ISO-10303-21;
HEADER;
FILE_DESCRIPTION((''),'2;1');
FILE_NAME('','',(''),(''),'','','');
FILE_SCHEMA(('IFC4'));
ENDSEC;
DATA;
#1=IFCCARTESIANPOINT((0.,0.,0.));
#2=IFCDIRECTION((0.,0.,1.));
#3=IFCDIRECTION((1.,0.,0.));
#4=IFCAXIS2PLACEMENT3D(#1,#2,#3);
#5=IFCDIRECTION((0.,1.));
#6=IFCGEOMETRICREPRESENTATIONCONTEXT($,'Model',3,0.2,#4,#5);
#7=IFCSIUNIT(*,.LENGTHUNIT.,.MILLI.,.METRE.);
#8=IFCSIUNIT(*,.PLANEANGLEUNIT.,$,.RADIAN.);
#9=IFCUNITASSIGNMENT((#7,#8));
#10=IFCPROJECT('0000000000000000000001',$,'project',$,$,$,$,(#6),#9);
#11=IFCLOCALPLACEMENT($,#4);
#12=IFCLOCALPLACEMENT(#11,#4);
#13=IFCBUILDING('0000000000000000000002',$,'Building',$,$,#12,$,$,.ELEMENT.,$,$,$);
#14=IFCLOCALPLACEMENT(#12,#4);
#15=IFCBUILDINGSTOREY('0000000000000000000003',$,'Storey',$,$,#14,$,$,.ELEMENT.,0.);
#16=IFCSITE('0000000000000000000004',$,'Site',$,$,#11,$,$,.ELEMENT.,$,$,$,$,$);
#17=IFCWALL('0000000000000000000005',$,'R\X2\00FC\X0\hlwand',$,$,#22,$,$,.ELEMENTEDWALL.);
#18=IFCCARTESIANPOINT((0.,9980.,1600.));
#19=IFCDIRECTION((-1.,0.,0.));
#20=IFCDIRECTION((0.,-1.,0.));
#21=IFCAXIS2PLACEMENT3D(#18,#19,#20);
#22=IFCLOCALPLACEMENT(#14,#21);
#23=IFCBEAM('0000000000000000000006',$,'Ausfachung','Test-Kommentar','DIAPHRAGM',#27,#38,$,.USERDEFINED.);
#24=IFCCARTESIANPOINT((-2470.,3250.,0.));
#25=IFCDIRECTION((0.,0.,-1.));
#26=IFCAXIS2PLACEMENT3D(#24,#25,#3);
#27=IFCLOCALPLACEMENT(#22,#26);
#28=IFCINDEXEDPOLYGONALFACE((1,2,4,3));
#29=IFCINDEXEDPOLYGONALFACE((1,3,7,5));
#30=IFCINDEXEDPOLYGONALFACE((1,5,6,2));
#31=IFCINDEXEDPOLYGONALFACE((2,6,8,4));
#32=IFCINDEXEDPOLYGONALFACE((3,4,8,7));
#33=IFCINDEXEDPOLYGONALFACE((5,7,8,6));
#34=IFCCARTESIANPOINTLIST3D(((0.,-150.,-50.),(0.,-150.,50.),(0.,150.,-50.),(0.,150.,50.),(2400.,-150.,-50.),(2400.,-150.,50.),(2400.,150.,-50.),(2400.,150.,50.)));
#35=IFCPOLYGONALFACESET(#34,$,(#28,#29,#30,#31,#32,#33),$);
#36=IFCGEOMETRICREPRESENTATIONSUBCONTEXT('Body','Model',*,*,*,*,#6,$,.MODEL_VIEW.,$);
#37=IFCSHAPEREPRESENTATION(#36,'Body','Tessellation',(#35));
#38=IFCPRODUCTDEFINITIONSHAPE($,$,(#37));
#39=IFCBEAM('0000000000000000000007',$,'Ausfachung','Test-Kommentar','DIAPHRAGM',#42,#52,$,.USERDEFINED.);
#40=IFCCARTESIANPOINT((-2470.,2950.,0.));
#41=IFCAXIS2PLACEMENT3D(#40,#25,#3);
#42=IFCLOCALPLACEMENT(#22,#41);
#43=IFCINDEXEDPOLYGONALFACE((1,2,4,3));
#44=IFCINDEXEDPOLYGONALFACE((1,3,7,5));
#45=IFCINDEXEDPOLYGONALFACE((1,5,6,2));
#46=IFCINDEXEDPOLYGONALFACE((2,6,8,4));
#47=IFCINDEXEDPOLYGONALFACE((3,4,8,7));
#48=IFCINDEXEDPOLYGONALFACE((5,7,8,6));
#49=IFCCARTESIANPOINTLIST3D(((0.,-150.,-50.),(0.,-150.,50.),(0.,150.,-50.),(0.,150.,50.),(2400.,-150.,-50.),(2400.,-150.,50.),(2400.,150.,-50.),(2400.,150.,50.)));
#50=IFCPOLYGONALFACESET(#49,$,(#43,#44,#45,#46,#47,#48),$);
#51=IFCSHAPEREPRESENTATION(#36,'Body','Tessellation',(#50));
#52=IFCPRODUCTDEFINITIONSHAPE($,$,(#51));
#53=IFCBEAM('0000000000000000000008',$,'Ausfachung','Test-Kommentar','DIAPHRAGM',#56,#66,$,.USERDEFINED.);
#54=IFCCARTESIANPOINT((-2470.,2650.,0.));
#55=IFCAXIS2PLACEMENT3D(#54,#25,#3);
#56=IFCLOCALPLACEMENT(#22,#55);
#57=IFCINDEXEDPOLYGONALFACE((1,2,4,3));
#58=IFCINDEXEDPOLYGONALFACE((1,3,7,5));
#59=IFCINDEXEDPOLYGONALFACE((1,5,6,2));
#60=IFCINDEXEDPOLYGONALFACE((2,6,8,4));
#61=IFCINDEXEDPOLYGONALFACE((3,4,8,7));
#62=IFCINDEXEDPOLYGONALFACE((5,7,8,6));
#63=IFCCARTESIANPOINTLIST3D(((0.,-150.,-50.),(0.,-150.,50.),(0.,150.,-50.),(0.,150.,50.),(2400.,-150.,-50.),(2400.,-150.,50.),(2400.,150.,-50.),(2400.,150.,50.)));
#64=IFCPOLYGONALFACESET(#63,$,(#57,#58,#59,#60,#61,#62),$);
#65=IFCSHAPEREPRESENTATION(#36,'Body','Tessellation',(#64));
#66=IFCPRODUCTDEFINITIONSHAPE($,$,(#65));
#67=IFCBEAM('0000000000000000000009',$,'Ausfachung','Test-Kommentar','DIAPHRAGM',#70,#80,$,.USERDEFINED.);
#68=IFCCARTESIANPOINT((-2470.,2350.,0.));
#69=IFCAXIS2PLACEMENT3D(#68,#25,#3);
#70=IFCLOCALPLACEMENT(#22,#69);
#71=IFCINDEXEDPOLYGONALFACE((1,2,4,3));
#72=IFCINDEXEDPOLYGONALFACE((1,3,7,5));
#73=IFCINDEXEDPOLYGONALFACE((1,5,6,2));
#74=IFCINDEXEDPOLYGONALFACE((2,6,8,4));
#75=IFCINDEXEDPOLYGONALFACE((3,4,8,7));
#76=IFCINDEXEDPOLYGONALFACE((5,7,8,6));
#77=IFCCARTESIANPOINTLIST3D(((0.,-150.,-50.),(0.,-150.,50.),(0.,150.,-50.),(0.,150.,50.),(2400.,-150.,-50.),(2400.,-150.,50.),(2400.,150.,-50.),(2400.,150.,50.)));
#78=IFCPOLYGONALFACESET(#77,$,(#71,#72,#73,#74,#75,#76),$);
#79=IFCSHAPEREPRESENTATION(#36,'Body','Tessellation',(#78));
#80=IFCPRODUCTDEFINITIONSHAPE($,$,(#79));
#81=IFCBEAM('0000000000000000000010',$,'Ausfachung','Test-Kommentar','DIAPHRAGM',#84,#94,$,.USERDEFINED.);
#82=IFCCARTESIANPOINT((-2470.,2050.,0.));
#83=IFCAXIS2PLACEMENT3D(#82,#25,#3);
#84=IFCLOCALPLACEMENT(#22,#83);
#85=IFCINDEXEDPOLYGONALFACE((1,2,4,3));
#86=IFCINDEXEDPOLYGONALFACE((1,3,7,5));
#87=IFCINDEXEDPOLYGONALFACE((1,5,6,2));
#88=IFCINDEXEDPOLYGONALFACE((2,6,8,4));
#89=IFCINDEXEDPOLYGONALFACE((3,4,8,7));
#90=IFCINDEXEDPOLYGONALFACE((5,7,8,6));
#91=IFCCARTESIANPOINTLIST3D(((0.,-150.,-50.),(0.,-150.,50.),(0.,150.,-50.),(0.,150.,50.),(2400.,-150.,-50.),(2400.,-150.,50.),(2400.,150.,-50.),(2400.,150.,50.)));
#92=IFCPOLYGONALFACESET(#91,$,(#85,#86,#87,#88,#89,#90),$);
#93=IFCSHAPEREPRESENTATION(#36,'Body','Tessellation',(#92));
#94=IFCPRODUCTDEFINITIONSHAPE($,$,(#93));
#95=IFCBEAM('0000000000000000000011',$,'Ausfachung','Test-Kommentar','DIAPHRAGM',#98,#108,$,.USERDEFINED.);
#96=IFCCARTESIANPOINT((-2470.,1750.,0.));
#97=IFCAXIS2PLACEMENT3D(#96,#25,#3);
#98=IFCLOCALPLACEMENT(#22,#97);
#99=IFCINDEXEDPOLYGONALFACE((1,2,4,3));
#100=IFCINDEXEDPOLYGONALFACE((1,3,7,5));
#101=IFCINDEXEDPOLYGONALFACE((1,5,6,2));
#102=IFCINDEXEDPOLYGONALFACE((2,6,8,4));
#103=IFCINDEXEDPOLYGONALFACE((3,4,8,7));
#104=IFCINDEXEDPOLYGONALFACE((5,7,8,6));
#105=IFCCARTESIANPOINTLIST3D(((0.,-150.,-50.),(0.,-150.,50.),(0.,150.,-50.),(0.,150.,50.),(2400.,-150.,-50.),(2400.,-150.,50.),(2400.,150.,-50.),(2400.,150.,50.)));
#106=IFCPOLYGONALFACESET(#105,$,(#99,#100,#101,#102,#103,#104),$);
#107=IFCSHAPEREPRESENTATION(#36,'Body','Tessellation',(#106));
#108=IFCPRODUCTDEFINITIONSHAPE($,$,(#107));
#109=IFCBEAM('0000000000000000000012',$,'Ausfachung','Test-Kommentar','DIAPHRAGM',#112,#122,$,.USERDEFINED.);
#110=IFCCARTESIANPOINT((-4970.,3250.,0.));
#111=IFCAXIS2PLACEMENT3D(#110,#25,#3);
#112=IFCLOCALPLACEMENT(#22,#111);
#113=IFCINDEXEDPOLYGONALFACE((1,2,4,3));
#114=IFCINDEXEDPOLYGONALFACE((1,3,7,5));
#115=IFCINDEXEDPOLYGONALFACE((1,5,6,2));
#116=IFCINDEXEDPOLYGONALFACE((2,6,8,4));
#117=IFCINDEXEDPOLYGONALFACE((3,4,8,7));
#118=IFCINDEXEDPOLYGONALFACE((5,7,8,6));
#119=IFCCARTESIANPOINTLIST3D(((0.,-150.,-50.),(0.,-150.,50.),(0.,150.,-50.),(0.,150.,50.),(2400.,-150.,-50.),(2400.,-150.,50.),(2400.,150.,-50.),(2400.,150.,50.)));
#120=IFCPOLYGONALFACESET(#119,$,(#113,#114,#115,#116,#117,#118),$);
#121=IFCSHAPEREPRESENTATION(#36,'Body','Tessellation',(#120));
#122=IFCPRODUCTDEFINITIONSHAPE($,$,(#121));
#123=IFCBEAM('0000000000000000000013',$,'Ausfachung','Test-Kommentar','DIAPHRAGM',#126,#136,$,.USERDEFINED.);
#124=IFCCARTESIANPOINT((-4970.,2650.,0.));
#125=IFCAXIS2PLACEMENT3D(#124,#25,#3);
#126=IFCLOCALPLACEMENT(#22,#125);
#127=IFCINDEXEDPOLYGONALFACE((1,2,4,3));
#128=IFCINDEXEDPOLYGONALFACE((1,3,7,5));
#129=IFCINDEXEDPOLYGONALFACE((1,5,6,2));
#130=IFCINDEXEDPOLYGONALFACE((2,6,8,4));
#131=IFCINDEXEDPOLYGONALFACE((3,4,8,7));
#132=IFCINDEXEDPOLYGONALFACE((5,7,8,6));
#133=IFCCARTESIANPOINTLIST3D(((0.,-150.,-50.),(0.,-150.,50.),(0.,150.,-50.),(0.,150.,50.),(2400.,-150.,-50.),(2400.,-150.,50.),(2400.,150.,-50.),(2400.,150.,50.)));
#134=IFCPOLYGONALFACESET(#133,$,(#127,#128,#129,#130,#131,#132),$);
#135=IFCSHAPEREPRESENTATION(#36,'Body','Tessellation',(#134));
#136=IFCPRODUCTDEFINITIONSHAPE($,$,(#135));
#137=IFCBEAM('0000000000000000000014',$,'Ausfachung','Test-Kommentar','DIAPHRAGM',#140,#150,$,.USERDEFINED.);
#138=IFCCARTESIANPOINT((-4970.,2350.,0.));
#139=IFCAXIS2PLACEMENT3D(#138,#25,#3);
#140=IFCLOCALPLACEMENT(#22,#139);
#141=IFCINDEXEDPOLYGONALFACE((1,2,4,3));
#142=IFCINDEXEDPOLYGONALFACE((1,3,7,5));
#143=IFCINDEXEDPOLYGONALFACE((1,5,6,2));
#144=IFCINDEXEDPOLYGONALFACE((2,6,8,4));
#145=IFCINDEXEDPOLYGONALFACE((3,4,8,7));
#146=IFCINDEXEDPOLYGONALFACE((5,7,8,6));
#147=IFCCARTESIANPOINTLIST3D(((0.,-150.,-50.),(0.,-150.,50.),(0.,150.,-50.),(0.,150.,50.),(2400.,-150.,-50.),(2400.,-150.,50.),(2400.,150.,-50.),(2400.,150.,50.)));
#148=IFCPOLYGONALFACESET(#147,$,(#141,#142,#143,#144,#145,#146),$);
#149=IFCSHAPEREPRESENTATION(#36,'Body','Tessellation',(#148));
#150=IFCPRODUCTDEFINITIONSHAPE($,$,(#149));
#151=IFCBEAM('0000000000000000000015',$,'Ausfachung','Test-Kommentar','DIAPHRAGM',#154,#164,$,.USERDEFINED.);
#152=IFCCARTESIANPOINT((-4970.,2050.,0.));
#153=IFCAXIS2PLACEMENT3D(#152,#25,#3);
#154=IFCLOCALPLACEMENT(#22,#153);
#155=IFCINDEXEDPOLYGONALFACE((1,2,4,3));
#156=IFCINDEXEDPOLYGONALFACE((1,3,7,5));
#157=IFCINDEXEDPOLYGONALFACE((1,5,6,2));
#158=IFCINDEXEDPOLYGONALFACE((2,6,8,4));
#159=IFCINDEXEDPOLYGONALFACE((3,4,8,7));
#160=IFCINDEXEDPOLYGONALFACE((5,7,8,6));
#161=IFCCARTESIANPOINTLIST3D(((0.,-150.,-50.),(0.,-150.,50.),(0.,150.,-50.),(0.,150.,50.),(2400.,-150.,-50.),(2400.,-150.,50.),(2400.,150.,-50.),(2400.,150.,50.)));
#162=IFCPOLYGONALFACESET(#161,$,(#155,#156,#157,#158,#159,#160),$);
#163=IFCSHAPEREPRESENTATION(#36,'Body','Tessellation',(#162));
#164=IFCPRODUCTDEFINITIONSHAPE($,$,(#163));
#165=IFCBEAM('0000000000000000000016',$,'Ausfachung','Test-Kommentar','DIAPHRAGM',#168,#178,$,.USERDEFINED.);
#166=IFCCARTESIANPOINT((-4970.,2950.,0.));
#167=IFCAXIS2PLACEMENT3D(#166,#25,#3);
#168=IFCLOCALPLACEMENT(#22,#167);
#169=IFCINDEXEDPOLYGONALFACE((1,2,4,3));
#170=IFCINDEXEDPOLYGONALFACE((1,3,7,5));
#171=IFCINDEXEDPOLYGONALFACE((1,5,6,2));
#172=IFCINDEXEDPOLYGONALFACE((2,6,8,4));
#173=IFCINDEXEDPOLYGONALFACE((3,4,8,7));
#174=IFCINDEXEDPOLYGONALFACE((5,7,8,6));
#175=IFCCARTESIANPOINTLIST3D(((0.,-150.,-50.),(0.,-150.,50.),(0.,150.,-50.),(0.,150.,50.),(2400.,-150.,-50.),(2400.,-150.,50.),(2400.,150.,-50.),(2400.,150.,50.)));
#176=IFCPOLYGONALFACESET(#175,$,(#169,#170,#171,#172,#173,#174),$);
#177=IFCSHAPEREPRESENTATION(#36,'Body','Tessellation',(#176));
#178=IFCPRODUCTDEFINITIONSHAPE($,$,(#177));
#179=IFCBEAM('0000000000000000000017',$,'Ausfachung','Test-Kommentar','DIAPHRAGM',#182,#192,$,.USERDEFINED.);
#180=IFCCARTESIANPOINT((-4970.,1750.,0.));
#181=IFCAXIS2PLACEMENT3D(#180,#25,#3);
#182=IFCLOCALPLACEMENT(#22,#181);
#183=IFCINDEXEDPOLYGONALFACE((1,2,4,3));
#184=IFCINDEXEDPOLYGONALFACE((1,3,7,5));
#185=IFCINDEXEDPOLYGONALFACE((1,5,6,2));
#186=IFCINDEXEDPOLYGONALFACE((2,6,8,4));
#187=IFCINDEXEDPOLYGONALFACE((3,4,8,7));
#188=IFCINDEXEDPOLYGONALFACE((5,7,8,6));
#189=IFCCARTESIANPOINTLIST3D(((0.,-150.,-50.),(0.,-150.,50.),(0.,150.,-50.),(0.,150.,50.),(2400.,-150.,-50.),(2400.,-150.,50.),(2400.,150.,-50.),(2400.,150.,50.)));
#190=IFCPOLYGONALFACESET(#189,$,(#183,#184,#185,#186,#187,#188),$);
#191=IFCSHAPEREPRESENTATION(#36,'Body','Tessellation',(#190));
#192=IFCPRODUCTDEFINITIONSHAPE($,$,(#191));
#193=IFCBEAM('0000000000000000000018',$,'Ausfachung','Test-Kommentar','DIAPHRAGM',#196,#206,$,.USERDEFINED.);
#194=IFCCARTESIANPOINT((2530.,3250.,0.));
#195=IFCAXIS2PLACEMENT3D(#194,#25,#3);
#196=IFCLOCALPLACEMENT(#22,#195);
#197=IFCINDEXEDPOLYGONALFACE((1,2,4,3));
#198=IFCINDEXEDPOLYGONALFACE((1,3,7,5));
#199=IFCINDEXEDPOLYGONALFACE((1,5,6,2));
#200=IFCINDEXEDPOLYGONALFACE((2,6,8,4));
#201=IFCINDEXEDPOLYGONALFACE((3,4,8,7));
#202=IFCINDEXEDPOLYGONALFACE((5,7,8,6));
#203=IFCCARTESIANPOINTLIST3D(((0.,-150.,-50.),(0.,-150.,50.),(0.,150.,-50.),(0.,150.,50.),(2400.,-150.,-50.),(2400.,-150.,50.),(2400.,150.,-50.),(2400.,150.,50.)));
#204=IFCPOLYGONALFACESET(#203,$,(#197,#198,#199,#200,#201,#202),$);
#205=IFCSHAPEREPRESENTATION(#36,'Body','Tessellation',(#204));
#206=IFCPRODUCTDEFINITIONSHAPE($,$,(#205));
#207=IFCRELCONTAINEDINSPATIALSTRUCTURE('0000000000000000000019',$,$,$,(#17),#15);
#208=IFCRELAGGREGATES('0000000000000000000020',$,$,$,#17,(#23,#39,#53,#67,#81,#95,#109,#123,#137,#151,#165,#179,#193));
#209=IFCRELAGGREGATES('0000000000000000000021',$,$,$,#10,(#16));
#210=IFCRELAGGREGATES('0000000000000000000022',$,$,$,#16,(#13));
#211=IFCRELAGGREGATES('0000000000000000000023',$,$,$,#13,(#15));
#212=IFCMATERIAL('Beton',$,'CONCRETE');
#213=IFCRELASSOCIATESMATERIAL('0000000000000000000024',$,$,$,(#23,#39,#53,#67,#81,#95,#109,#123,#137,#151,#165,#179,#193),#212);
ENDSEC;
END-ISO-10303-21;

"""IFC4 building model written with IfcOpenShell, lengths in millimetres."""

from ifc_helpers import new_model, si_unit, direction, frame, origin_with_axes, place, context, subcontext, project, spatial, line, indexed_curve, outline, extrude, material, element, aggregate, save


model = new_model("IFC4")

# Units and contexts
model_context = context("Model", 3, precision=0.2, world=origin_with_axes(), true_north=direction((0.0, 1.0)))
body_context = subcontext(model_context, "Body", "Model", "MODEL_VIEW")
ifc_project = project(units=[si_unit("LENGTHUNIT", "METRE", prefix="MILLI"), si_unit("PLANEANGLEUNIT", "RADIAN")], contexts=[model_context])

# Site, building, storey
site_placement = place(None, origin_with_axes())
site = spatial("IfcSite", under=ifc_project, at=site_placement, Name="Site", CompositionType="ELEMENT")
building_placement = place(site_placement, origin_with_axes())
building = spatial("IfcBuilding", under=site, at=building_placement, Name="Building", CompositionType="ELEMENT")
storey_placement = place(building_placement, origin_with_axes())
storey = spatial("IfcBuildingStorey", under=building, at=storey_placement, Name="Storey", CompositionType="ELEMENT", Elevation=0.0)

# Wall, beams
wall_placement = place(storey_placement, frame((0.0, 9980.0, 1600.0), z_axis=(-1.0, 0.0, 0.0), x_axis=(0.0, -1.0, 0.0)))
wall = element("IfcWall", 1, at=wall_placement, inside=storey, Name="Rühlwand", PredefinedType="ELEMENTEDWALL")
ifc_material_1 = material(Name="Beton", Category="CONCRETE")
beam_1_placement = place(wall_placement, frame((-2470.0, 3250.0, 0.0), z_axis=(0.0, 0.0, -1.0), x_axis=(1.0, 0.0, 0.0)))
beam_1 = element("IfcBeam", 2, at=beam_1_placement, material=ifc_material_1, Name="Ausfachung", Description="Test-Kommentar", ObjectType="DIAPHRAGM", PredefinedType="USERDEFINED", context=body_context, shape_type="SolidModel", body=[
    extrude(outline(indexed_curve([(-50.0, -150.0), (50.0, -150.0), (50.0, 150.0), (-50.0, 150.0)], segments=[line(1, 2, 3, 4, 1)])), frame((0.0, 0.0, 0.0), z_axis=(-1.0, 0.0, 0.0), x_axis=(0.0, 0.0, 1.0)), (0.0, 0.0, -1.0), 2400.0),
])
beam_2_placement = place(wall_placement, frame((-2470.0, 2950.0, 0.0), z_axis=(0.0, 0.0, -1.0), x_axis=(1.0, 0.0, 0.0)))
beam_2 = element("IfcBeam", 3, at=beam_2_placement, material=ifc_material_1, Name="Ausfachung", Description="Test-Kommentar", ObjectType="DIAPHRAGM", PredefinedType="USERDEFINED", context=body_context, shape_type="SolidModel", body=[
    extrude(outline(indexed_curve([(-50.0, -150.0), (50.0, -150.0), (50.0, 150.0), (-50.0, 150.0)], segments=[line(1, 2, 3, 4, 1)])), frame((0.0, 0.0, 0.0), z_axis=(-1.0, 0.0, 0.0), x_axis=(0.0, 0.0, 1.0)), (0.0, 0.0, -1.0), 2400.0),
])
beam_3_placement = place(wall_placement, frame((-2470.0, 2650.0, 0.0), z_axis=(0.0, 0.0, -1.0), x_axis=(1.0, 0.0, 0.0)))
beam_3 = element("IfcBeam", 4, at=beam_3_placement, material=ifc_material_1, Name="Ausfachung", Description="Test-Kommentar", ObjectType="DIAPHRAGM", PredefinedType="USERDEFINED", context=body_context, shape_type="SolidModel", body=[
    extrude(outline(indexed_curve([(-50.0, -150.0), (50.0, -150.0), (50.0, 150.0), (-50.0, 150.0)], segments=[line(1, 2, 3, 4, 1)])), frame((0.0, 0.0, 0.0), z_axis=(-1.0, 0.0, 0.0), x_axis=(0.0, 0.0, 1.0)), (0.0, 0.0, -1.0), 2400.0),
])
beam_4_placement = place(wall_placement, frame((-2470.0, 2350.0, 0.0), z_axis=(0.0, 0.0, -1.0), x_axis=(1.0, 0.0, 0.0)))
beam_4 = element("IfcBeam", 5, at=beam_4_placement, material=ifc_material_1, Name="Ausfachung", Description="Test-Kommentar", ObjectType="DIAPHRAGM", PredefinedType="USERDEFINED", context=body_context, shape_type="SolidModel", body=[
    extrude(outline(indexed_curve([(-50.0, -150.0), (50.0, -150.0), (50.0, 150.0), (-50.0, 150.0)], segments=[line(1, 2, 3, 4, 1)])), frame((0.0, 0.0, 0.0), z_axis=(-1.0, 0.0, 0.0), x_axis=(0.0, 0.0, 1.0)), (0.0, 0.0, -1.0), 2400.0),
])
beam_5_placement = place(wall_placement, frame((-2470.0, 2050.0, 0.0), z_axis=(0.0, 0.0, -1.0), x_axis=(1.0, 0.0, 0.0)))
beam_5 = element("IfcBeam", 6, at=beam_5_placement, material=ifc_material_1, Name="Ausfachung", Description="Test-Kommentar", ObjectType="DIAPHRAGM", PredefinedType="USERDEFINED", context=body_context, shape_type="SolidModel", body=[
    extrude(outline(indexed_curve([(-50.0, -150.0), (50.0, -150.0), (50.0, 150.0), (-50.0, 150.0)], segments=[line(1, 2, 3, 4, 1)])), frame((0.0, 0.0, 0.0), z_axis=(-1.0, 0.0, 0.0), x_axis=(0.0, 0.0, 1.0)), (0.0, 0.0, -1.0), 2400.0),
])
beam_6_placement = place(wall_placement, frame((-2470.0, 1750.0, 0.0), z_axis=(0.0, 0.0, -1.0), x_axis=(1.0, 0.0, 0.0)))
beam_6 = element("IfcBeam", 7, at=beam_6_placement, material=ifc_material_1, Name="Ausfachung", Description="Test-Kommentar", ObjectType="DIAPHRAGM", PredefinedType="USERDEFINED", context=body_context, shape_type="SolidModel", body=[
    extrude(outline(indexed_curve([(-50.0, -150.0), (50.0, -150.0), (50.0, 150.0), (-50.0, 150.0)], segments=[line(1, 2, 3, 4, 1)])), frame((0.0, 0.0, 0.0), z_axis=(-1.0, 0.0, 0.0), x_axis=(0.0, 0.0, 1.0)), (0.0, 0.0, -1.0), 2400.0),
])
beam_7_placement = place(wall_placement, frame((-4970.0, 3250.0, 0.0), z_axis=(0.0, 0.0, -1.0), x_axis=(1.0, 0.0, 0.0)))
beam_7 = element("IfcBeam", 8, at=beam_7_placement, material=ifc_material_1, Name="Ausfachung", Description="Test-Kommentar", ObjectType="DIAPHRAGM", PredefinedType="USERDEFINED", context=body_context, shape_type="SolidModel", body=[
    extrude(outline(indexed_curve([(-50.0, -150.0), (50.0, -150.0), (50.0, 150.0), (-50.0, 150.0)], segments=[line(1, 2, 3, 4, 1)])), frame((0.0, 0.0, 0.0), z_axis=(-1.0, 0.0, 0.0), x_axis=(0.0, 0.0, 1.0)), (0.0, 0.0, -1.0), 2400.0),
])
beam_8_placement = place(wall_placement, frame((-4970.0, 2650.0, 0.0), z_axis=(0.0, 0.0, -1.0), x_axis=(1.0, 0.0, 0.0)))
beam_8 = element("IfcBeam", 9, at=beam_8_placement, material=ifc_material_1, Name="Ausfachung", Description="Test-Kommentar", ObjectType="DIAPHRAGM", PredefinedType="USERDEFINED", context=body_context, shape_type="SolidModel", body=[
    extrude(outline(indexed_curve([(-50.0, -150.0), (50.0, -150.0), (50.0, 150.0), (-50.0, 150.0)], segments=[line(1, 2, 3, 4, 1)])), frame((0.0, 0.0, 0.0), z_axis=(-1.0, 0.0, 0.0), x_axis=(0.0, 0.0, 1.0)), (0.0, 0.0, -1.0), 2400.0),
])
beam_9_placement = place(wall_placement, frame((-4970.0, 2350.0, 0.0), z_axis=(0.0, 0.0, -1.0), x_axis=(1.0, 0.0, 0.0)))
beam_9 = element("IfcBeam", 10, at=beam_9_placement, material=ifc_material_1, Name="Ausfachung", Description="Test-Kommentar", ObjectType="DIAPHRAGM", PredefinedType="USERDEFINED", context=body_context, shape_type="SolidModel", body=[
    extrude(outline(indexed_curve([(-50.0, -150.0), (50.0, -150.0), (50.0, 150.0), (-50.0, 150.0)], segments=[line(1, 2, 3, 4, 1)])), frame((0.0, 0.0, 0.0), z_axis=(-1.0, 0.0, 0.0), x_axis=(0.0, 0.0, 1.0)), (0.0, 0.0, -1.0), 2400.0),
])
beam_10_placement = place(wall_placement, frame((-4970.0, 2050.0, 0.0), z_axis=(0.0, 0.0, -1.0), x_axis=(1.0, 0.0, 0.0)))
beam_10 = element("IfcBeam", 11, at=beam_10_placement, material=ifc_material_1, Name="Ausfachung", Description="Test-Kommentar", ObjectType="DIAPHRAGM", PredefinedType="USERDEFINED", context=body_context, shape_type="SolidModel", body=[
    extrude(outline(indexed_curve([(-50.0, -150.0), (50.0, -150.0), (50.0, 150.0), (-50.0, 150.0)], segments=[line(1, 2, 3, 4, 1)])), frame((0.0, 0.0, 0.0), z_axis=(-1.0, 0.0, 0.0), x_axis=(0.0, 0.0, 1.0)), (0.0, 0.0, -1.0), 2400.0),
])
beam_11_placement = place(wall_placement, frame((-4970.0, 2950.0, 0.0), z_axis=(0.0, 0.0, -1.0), x_axis=(1.0, 0.0, 0.0)))
beam_11 = element("IfcBeam", 12, at=beam_11_placement, material=ifc_material_1, Name="Ausfachung", Description="Test-Kommentar", ObjectType="DIAPHRAGM", PredefinedType="USERDEFINED", context=body_context, shape_type="SolidModel", body=[
    extrude(outline(indexed_curve([(-50.0, -150.0), (50.0, -150.0), (50.0, 150.0), (-50.0, 150.0)], segments=[line(1, 2, 3, 4, 1)])), frame((0.0, 0.0, 0.0), z_axis=(-1.0, 0.0, 0.0), x_axis=(0.0, 0.0, 1.0)), (0.0, 0.0, -1.0), 2400.0),
])
beam_12_placement = place(wall_placement, frame((-4970.0, 1750.0, 0.0), z_axis=(0.0, 0.0, -1.0), x_axis=(1.0, 0.0, 0.0)))
beam_12 = element("IfcBeam", 13, at=beam_12_placement, material=ifc_material_1, Name="Ausfachung", Description="Test-Kommentar", ObjectType="DIAPHRAGM", PredefinedType="USERDEFINED", context=body_context, shape_type="SolidModel", body=[
    extrude(outline(indexed_curve([(-50.0, -150.0), (50.0, -150.0), (50.0, 150.0), (-50.0, 150.0)], segments=[line(1, 2, 3, 4, 1)])), frame((0.0, 0.0, 0.0), z_axis=(-1.0, 0.0, 0.0), x_axis=(0.0, 0.0, 1.0)), (0.0, 0.0, -1.0), 2400.0),
])
beam_13_placement = place(wall_placement, frame((2530.0, 3250.0, 0.0), z_axis=(0.0, 0.0, -1.0), x_axis=(1.0, 0.0, 0.0)))
beam_13 = element("IfcBeam", 14, at=beam_13_placement, material=ifc_material_1, Name="Ausfachung", Description="Test-Kommentar", ObjectType="DIAPHRAGM", PredefinedType="USERDEFINED", context=body_context, shape_type="SolidModel", body=[
    extrude(outline(indexed_curve([(-50.0, -150.0), (50.0, -150.0), (50.0, 150.0), (-50.0, 150.0)], segments=[line(1, 2, 3, 4, 1)])), frame((0.0, 0.0, 0.0), z_axis=(-1.0, 0.0, 0.0), x_axis=(0.0, 0.0, 1.0)), (0.0, 0.0, -1.0), 2400.0),
])
aggregate(wall, [beam_1, beam_2, beam_3, beam_4, beam_5, beam_6, beam_7, beam_8, beam_9, beam_10, beam_11, beam_12, beam_13])

save(model, "model.ifc")
